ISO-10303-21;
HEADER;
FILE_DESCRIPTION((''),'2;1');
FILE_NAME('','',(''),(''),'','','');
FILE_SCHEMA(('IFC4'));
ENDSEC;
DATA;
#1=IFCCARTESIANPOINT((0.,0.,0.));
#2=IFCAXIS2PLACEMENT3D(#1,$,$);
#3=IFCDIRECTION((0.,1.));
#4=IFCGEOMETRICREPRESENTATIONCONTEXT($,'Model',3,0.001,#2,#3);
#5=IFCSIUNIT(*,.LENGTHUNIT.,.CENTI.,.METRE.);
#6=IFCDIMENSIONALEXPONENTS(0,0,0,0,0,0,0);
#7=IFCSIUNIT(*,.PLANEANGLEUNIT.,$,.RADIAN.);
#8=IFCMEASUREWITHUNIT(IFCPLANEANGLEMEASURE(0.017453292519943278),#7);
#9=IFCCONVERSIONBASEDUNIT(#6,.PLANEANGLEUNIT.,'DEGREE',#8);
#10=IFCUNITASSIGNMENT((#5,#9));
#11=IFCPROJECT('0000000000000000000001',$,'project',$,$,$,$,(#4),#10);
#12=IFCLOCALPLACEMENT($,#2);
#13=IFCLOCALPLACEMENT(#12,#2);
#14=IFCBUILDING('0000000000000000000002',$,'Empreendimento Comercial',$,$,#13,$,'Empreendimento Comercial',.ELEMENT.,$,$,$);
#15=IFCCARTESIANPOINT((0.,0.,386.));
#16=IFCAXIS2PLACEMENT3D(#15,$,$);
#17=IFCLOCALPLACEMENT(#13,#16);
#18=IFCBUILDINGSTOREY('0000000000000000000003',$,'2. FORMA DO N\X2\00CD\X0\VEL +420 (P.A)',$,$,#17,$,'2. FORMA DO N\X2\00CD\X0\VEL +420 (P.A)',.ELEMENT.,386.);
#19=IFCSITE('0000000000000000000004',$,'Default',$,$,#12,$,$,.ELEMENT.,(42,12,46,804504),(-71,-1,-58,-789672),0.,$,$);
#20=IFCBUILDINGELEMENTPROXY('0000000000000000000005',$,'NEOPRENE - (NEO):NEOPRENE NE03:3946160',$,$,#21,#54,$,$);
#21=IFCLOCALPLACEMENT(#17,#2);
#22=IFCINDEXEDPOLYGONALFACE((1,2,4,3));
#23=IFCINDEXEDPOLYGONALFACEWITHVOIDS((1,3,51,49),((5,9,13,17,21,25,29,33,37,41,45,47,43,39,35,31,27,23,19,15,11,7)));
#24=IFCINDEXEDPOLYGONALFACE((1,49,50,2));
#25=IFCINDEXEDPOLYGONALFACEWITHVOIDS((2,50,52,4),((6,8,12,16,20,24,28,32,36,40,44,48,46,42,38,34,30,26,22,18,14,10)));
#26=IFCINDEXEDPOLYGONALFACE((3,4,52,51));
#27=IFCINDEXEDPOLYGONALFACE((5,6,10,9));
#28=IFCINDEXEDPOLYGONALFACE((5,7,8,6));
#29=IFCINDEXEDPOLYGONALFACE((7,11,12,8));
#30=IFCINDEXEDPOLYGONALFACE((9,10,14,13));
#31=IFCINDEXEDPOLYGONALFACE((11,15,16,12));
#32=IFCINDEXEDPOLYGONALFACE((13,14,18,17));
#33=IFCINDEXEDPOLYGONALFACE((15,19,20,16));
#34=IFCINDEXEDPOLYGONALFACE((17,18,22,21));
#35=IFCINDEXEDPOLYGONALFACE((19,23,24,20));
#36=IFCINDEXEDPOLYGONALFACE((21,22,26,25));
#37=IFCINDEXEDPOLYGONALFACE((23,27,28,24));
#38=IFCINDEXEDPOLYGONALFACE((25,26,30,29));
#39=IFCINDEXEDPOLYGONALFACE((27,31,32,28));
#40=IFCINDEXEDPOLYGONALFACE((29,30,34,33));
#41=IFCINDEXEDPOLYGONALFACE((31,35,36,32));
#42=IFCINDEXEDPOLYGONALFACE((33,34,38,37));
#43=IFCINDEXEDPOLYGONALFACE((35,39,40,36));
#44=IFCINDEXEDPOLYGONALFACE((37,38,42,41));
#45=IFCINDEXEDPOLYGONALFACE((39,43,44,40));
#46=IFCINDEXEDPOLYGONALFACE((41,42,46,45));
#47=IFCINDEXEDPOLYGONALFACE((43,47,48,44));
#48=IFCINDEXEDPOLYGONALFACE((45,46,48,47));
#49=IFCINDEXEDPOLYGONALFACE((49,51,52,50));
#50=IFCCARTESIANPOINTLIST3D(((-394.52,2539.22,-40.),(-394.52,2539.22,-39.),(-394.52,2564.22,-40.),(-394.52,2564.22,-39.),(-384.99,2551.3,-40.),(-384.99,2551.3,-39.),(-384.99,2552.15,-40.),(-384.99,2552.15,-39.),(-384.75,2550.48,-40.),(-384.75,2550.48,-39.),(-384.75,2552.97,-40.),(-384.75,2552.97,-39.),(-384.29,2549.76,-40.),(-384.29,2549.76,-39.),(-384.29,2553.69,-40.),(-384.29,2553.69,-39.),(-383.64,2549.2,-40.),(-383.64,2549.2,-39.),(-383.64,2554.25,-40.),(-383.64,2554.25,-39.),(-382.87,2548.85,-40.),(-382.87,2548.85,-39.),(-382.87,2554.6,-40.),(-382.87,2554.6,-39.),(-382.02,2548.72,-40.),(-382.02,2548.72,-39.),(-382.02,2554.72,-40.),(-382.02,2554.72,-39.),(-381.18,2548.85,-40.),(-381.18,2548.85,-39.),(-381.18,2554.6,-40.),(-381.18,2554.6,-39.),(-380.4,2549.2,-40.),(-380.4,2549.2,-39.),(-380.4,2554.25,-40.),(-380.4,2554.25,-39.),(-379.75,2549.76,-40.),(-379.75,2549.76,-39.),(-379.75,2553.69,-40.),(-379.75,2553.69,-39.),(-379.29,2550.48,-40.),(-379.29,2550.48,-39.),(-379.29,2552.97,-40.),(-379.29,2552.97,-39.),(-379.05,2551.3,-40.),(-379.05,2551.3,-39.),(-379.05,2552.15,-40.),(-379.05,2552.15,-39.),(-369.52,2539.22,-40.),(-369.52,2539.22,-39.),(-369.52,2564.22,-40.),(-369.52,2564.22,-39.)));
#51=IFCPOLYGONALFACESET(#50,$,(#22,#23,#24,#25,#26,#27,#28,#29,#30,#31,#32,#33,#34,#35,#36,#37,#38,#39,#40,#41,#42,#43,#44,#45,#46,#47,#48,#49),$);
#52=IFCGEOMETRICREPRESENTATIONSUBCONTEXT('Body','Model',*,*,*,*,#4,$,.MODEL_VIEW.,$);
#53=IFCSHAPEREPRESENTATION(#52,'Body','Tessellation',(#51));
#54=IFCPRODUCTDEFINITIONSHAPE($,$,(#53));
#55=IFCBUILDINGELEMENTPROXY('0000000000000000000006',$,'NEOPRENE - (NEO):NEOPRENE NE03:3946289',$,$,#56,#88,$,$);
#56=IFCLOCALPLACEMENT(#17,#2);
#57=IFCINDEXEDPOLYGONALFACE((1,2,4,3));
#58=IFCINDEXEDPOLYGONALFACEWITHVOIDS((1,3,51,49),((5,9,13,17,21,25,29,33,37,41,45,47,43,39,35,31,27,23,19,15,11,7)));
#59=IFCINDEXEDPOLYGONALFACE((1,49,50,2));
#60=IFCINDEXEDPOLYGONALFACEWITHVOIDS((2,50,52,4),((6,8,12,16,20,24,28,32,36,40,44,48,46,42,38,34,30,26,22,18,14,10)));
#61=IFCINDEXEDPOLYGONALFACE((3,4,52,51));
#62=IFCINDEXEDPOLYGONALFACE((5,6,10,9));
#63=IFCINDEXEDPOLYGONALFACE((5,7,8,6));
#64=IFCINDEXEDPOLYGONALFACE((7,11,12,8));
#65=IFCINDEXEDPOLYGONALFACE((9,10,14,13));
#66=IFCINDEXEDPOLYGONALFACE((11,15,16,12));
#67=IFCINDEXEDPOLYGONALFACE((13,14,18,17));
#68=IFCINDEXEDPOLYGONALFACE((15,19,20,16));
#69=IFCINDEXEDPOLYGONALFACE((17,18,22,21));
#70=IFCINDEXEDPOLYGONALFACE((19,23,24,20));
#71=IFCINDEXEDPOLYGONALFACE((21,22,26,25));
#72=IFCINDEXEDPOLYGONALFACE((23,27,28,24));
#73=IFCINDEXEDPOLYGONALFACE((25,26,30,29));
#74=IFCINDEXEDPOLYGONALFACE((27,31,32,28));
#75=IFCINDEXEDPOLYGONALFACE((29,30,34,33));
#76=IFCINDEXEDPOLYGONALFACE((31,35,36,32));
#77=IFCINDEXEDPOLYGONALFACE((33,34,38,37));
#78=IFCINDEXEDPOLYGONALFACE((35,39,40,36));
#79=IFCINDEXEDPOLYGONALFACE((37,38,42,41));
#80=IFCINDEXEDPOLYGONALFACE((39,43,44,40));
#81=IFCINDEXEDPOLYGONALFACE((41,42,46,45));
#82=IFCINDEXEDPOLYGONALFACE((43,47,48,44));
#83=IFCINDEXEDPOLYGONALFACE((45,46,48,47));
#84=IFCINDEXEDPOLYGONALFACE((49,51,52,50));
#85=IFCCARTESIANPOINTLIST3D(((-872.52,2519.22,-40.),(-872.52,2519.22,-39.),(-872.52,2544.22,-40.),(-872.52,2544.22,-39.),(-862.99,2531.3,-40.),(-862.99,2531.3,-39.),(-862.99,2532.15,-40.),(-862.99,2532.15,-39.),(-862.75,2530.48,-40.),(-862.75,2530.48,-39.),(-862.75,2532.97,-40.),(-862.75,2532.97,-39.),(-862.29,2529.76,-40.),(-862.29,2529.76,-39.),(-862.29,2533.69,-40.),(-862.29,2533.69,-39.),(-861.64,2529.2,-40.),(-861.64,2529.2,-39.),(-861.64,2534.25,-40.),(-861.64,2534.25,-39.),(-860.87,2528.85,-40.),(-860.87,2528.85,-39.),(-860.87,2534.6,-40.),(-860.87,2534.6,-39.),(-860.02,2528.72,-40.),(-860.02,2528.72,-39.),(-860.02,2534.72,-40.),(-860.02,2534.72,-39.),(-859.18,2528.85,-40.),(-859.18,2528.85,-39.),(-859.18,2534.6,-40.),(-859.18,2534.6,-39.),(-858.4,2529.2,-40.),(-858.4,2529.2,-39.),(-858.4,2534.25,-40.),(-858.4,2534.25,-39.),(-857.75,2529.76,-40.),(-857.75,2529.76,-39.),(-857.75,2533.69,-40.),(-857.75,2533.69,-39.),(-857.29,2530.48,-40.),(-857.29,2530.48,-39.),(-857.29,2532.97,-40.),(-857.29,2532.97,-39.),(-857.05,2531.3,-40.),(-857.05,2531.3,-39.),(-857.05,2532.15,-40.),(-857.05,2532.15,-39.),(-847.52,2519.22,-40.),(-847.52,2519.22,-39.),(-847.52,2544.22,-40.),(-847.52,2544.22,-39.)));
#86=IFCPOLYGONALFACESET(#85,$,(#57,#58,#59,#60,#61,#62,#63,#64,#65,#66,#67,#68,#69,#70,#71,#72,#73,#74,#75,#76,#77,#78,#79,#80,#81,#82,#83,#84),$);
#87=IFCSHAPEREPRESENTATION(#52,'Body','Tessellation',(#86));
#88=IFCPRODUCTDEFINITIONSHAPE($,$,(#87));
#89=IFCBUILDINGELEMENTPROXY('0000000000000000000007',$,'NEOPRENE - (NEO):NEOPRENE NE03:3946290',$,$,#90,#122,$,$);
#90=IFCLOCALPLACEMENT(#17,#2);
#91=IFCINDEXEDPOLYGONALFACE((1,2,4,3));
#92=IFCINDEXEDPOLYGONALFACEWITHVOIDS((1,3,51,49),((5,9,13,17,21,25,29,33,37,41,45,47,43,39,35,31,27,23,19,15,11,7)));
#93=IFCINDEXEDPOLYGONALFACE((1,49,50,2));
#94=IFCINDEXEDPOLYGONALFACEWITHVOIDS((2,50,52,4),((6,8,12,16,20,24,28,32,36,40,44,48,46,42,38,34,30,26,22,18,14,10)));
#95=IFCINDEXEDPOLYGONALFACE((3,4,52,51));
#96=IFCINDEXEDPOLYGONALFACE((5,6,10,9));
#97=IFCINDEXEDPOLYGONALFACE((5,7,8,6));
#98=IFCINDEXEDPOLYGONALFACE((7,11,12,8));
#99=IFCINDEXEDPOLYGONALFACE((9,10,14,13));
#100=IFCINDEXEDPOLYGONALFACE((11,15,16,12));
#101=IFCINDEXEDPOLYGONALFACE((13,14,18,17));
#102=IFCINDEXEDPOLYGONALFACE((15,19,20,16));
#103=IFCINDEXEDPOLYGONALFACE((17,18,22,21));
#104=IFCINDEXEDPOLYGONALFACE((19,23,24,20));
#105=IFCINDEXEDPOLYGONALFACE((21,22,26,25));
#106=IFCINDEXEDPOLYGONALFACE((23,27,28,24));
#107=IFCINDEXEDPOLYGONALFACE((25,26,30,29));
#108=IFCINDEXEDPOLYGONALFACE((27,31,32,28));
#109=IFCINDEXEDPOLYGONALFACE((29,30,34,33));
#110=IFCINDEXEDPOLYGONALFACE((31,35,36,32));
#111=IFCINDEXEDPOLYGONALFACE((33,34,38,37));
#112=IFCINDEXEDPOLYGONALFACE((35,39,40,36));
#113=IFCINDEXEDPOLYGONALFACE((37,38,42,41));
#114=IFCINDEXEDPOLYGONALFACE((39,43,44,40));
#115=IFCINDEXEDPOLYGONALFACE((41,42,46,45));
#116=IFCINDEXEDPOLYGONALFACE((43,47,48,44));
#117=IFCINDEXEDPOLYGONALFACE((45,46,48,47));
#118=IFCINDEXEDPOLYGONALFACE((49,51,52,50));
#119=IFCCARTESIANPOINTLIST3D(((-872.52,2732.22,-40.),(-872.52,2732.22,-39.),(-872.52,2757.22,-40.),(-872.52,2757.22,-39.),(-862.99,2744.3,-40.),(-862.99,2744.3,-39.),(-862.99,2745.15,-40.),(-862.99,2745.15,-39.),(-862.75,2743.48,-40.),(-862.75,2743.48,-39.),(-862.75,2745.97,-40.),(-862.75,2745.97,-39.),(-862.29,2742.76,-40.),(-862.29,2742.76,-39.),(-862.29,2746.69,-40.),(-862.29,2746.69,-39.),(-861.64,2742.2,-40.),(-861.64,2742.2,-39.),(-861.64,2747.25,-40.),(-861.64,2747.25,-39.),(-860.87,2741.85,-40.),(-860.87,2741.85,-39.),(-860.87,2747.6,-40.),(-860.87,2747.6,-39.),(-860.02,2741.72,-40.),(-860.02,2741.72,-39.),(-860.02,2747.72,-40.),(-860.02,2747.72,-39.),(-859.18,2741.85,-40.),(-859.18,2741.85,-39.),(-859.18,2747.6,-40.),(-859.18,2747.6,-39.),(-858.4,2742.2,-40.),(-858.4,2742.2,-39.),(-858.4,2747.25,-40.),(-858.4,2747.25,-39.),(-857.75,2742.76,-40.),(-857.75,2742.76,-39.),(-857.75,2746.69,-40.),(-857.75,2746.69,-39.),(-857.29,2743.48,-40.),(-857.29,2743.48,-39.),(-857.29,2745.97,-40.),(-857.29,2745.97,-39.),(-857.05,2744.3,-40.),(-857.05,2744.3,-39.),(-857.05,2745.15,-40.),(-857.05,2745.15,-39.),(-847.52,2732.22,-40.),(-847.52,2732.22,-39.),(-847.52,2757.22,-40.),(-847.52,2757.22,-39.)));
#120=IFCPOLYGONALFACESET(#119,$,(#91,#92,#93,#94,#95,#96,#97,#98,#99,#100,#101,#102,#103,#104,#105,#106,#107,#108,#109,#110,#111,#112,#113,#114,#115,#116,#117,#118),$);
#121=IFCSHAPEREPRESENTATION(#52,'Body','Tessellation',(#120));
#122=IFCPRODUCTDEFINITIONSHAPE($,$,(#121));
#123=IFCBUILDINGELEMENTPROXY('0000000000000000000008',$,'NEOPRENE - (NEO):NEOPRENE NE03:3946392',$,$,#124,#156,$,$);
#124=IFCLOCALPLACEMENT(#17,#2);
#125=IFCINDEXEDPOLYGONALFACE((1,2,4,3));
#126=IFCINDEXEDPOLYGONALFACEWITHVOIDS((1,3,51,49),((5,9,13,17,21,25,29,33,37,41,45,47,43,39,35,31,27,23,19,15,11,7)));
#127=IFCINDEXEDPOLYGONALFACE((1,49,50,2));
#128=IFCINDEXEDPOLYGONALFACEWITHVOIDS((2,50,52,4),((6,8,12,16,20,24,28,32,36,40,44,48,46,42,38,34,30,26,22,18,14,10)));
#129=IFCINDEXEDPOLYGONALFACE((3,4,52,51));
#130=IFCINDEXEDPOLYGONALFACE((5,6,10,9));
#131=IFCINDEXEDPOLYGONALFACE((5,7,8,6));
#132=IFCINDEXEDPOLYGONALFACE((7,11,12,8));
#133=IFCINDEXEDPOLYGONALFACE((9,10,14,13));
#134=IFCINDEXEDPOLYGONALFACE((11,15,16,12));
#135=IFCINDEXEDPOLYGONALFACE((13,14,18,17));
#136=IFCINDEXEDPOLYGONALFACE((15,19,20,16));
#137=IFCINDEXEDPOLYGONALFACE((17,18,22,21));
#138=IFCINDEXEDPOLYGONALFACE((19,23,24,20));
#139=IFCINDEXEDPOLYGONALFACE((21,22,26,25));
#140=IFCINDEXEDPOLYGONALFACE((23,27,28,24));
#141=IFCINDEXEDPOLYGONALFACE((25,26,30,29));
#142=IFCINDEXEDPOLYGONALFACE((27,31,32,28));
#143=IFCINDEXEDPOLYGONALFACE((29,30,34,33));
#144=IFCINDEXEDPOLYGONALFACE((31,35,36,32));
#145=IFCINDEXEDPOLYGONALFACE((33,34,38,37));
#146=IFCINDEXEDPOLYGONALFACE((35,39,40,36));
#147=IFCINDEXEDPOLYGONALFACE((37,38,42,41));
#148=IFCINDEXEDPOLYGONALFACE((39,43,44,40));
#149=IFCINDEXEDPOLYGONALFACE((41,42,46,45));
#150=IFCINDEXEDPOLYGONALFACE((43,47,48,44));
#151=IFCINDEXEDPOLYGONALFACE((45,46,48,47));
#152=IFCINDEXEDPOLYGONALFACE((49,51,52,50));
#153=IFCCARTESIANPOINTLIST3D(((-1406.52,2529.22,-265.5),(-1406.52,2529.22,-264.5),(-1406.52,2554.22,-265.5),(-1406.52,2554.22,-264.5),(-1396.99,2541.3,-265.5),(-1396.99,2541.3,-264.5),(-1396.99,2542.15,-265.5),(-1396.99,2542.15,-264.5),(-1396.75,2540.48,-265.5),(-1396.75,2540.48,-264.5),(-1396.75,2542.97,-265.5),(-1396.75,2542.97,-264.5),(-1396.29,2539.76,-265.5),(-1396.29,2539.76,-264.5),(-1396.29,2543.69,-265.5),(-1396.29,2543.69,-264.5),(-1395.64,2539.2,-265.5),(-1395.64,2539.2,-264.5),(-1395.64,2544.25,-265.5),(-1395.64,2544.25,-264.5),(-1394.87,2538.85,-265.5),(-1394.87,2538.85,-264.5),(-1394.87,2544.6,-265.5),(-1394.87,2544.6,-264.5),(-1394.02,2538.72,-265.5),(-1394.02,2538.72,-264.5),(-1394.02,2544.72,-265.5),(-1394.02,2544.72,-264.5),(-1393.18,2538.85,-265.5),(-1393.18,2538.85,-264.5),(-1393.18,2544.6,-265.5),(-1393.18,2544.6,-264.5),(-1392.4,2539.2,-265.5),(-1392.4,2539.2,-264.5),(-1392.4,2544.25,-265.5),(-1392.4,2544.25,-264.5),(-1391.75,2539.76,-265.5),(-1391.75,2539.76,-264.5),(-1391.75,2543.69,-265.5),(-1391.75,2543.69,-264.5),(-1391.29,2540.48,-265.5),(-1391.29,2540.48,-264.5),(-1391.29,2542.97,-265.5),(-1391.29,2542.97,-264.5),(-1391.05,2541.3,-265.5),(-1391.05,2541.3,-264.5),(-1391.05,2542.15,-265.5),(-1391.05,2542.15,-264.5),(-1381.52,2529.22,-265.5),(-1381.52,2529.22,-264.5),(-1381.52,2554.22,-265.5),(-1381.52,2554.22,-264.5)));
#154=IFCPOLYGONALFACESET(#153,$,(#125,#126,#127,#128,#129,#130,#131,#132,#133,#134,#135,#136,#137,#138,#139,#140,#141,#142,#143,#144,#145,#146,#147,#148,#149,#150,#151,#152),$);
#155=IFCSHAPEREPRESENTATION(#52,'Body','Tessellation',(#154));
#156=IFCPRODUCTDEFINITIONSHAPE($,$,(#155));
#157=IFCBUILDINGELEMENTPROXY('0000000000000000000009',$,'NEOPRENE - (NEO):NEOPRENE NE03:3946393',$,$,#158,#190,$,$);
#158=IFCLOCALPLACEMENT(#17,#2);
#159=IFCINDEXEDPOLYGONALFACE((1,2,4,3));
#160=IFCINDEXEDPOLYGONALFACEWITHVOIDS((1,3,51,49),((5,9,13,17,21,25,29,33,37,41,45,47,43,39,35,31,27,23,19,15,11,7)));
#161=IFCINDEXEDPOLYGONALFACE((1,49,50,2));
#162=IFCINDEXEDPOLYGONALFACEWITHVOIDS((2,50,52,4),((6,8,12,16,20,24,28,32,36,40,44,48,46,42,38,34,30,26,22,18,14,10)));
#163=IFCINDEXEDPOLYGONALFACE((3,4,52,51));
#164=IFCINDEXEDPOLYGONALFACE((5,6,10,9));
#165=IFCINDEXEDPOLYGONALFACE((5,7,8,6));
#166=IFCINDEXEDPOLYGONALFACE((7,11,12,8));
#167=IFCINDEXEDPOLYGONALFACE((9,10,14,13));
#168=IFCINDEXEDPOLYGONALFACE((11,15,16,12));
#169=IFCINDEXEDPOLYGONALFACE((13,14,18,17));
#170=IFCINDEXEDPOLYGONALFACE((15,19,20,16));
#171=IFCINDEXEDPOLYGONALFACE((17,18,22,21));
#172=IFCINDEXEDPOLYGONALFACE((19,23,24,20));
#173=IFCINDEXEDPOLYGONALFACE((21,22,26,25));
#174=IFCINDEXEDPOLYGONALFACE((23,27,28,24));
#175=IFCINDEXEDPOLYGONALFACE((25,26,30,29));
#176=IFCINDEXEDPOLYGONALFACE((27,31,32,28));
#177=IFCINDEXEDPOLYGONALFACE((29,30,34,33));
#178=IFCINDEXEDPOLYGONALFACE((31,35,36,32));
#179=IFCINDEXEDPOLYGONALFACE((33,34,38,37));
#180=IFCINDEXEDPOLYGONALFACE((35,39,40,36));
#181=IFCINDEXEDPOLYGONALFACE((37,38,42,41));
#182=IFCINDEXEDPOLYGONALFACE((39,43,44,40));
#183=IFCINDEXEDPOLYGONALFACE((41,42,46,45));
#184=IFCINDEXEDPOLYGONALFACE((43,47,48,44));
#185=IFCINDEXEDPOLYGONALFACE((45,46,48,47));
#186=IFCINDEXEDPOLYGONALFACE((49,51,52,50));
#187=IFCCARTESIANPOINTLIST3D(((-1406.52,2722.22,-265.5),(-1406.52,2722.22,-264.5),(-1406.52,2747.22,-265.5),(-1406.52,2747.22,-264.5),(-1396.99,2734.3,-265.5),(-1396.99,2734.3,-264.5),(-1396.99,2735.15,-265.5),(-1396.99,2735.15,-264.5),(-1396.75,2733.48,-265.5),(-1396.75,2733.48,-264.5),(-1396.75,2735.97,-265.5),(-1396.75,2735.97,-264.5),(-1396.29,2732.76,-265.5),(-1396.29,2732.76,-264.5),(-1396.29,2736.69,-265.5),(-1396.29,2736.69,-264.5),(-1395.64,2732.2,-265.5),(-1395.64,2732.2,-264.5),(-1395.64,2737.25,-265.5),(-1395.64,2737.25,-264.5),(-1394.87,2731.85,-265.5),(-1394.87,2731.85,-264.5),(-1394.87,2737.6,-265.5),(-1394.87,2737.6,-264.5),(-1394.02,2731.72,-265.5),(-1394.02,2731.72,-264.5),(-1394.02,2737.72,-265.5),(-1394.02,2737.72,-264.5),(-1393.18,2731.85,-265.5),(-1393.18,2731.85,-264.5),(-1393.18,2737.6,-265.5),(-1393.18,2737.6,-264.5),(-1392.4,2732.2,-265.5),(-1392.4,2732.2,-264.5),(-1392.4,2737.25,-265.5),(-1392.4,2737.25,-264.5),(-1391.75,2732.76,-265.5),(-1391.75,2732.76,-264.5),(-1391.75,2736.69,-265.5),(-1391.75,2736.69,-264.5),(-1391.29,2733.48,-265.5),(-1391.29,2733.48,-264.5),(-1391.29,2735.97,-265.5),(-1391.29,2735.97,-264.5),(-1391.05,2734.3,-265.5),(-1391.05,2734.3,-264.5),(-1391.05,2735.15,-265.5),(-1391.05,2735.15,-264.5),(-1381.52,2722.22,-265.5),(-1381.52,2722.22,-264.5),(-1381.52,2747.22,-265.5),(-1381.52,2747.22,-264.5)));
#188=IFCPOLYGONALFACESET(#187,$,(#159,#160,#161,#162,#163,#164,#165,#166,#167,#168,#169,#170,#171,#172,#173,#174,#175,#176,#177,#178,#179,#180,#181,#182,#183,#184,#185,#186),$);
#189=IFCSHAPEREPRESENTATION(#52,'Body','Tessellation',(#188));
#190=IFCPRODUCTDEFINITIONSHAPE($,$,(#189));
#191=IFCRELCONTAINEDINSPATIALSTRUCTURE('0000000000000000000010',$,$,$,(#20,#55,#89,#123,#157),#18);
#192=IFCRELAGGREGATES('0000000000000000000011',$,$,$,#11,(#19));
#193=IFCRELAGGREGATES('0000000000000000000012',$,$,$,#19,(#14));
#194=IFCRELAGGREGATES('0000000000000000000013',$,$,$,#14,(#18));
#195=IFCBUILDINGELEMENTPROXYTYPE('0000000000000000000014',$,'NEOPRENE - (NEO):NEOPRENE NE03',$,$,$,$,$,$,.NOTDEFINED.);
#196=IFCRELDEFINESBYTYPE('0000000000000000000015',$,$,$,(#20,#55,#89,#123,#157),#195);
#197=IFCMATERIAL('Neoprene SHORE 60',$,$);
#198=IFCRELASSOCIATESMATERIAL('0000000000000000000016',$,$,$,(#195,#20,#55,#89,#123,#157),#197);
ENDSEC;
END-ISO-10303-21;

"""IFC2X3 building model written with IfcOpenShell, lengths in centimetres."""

from ifc_helpers import new_model, entity, si_unit, converted_unit, direction, frame, frame_2d, origin, place, context, subcontext, project, spatial, polyline, circle_curve, parameter, trimmed, segment, composite_curve, outline, extrude, source, transform, mapped, material, type_object, type_shapes, element, save


model = new_model("IFC2X3")

# Units and contexts
model_context = context("Model", 3, precision=0.001, world=origin(), true_north=direction((0.0, 1.0)))
body_context = subcontext(model_context, "Body", "Model", "MODEL_VIEW")
ifc_project = project(units=[si_unit("LENGTHUNIT", "METRE", prefix="CENTI"), converted_unit("PLANEANGLEUNIT", "DEGREE", entity("IfcPlaneAngleMeasure", 0.017453292519943278), si_unit("PLANEANGLEUNIT", "RADIAN"), dimensions=[0, 0, 0, 0, 0, 0, 0])], contexts=[model_context])

# Site, building, storey
site_placement = place(None, origin())
site = spatial("IfcSite", under=ifc_project, at=site_placement, Name="Default", CompositionType="ELEMENT", RefLatitude=(42, 12, 46, 804504), RefLongitude=(-71, -1, -58, -789672), RefElevation=0.0)
building_placement = place(site_placement, origin())
building = spatial("IfcBuilding", under=site, at=building_placement, Name="Empreendimento Comercial", LongName="Empreendimento Comercial", CompositionType="ELEMENT")
storey_placement = place(building_placement, frame((0.0, 0.0, 386.0)))
storey = spatial("IfcBuildingStorey", under=building, at=storey_placement, Name="2. FORMA DO NÍVEL +420 (P.A)", LongName="2. FORMA DO NÍVEL +420 (P.A)", CompositionType="ELEMENT", Elevation=386.0)

# Building element proxies
ifc_material = material(Name="Neoprene SHORE 60")
building_element_proxy_type_1 = type_object("IfcBuildingElementProxyType", Name="NEOPRENE - (NEO):NEOPRENE NE03", PredefinedType="NOTDEFINED", material=ifc_material)
shared_shape_1 = source(origin(), body_context, "Body", "SweptSolid", [
    extrude(outline(polyline([(-12.5, -12.5), (12.5, -12.5), (12.5, 12.5), (-12.5, 12.5), (-12.5, -12.5)]), holes=[composite_curve([segment(trimmed(circle_curve(frame_2d((0.0, 0.0), x_axis=(-1.0, 0.0)), 3.0), [parameter(0.0)], [parameter(180.0)], True, "PARAMETER"), False, "CONTINUOUS"), segment(trimmed(circle_curve(frame_2d((0.0, 0.0), x_axis=(-1.0, 0.0)), 3.0), [parameter(180.0)], [parameter(0.0)], True, "PARAMETER"), False, "CONTINUOUS")], self_intersect=False)]), frame((0.0, 0.0, -71.0), z_axis=(0.0, 0.0, 1.0), x_axis=(-1.0, 0.0, 0.0)), (0.0, 0.0, 1.0), 1.0),
])
type_shapes(building_element_proxy_type_1, [shared_shape_1])
for number, where, z_axis, x_axis, name in (
    (1, (-382.02, 2551.72, 31.0), (0.0, 0.0, 1.0), (0.0, -1.0, 0.0), "NEOPRENE - (NEO):NEOPRENE NE03:3946160"),
    (2, (-860.02, 2531.72, 31.0), (0.0, 0.0, 1.0), (0.0, -1.0, 0.0), "NEOPRENE - (NEO):NEOPRENE NE03:3946289"),
    (3, (-860.02, 2744.72, 31.0), (0.0, 0.0, 1.0), (0.0, -1.0, 0.0), "NEOPRENE - (NEO):NEOPRENE NE03:3946290"),
    (4, (-1394.02, 2541.72, -194.5), (0.0, 0.0, 1.0), (0.0, -1.0, 0.0), "NEOPRENE - (NEO):NEOPRENE NE03:3946392"),
    (5, (-1394.02, 2734.72, -194.5), (0.0, 0.0, 1.0), (0.0, -1.0, 0.0), "NEOPRENE - (NEO):NEOPRENE NE03:3946393"),
):
    element("IfcBuildingElementProxy", number, at=place(storey_placement, frame(where, z_axis=z_axis, x_axis=x_axis)), inside=storey, type_object=building_element_proxy_type_1, material=ifc_material, Name=name, context=body_context, shape_type="MappedRepresentation", body=[
        mapped(shared_shape_1, transform((0.0, 0.0, 0.0), scale=1.0)),
    ])

save(model, "model.ifc")
